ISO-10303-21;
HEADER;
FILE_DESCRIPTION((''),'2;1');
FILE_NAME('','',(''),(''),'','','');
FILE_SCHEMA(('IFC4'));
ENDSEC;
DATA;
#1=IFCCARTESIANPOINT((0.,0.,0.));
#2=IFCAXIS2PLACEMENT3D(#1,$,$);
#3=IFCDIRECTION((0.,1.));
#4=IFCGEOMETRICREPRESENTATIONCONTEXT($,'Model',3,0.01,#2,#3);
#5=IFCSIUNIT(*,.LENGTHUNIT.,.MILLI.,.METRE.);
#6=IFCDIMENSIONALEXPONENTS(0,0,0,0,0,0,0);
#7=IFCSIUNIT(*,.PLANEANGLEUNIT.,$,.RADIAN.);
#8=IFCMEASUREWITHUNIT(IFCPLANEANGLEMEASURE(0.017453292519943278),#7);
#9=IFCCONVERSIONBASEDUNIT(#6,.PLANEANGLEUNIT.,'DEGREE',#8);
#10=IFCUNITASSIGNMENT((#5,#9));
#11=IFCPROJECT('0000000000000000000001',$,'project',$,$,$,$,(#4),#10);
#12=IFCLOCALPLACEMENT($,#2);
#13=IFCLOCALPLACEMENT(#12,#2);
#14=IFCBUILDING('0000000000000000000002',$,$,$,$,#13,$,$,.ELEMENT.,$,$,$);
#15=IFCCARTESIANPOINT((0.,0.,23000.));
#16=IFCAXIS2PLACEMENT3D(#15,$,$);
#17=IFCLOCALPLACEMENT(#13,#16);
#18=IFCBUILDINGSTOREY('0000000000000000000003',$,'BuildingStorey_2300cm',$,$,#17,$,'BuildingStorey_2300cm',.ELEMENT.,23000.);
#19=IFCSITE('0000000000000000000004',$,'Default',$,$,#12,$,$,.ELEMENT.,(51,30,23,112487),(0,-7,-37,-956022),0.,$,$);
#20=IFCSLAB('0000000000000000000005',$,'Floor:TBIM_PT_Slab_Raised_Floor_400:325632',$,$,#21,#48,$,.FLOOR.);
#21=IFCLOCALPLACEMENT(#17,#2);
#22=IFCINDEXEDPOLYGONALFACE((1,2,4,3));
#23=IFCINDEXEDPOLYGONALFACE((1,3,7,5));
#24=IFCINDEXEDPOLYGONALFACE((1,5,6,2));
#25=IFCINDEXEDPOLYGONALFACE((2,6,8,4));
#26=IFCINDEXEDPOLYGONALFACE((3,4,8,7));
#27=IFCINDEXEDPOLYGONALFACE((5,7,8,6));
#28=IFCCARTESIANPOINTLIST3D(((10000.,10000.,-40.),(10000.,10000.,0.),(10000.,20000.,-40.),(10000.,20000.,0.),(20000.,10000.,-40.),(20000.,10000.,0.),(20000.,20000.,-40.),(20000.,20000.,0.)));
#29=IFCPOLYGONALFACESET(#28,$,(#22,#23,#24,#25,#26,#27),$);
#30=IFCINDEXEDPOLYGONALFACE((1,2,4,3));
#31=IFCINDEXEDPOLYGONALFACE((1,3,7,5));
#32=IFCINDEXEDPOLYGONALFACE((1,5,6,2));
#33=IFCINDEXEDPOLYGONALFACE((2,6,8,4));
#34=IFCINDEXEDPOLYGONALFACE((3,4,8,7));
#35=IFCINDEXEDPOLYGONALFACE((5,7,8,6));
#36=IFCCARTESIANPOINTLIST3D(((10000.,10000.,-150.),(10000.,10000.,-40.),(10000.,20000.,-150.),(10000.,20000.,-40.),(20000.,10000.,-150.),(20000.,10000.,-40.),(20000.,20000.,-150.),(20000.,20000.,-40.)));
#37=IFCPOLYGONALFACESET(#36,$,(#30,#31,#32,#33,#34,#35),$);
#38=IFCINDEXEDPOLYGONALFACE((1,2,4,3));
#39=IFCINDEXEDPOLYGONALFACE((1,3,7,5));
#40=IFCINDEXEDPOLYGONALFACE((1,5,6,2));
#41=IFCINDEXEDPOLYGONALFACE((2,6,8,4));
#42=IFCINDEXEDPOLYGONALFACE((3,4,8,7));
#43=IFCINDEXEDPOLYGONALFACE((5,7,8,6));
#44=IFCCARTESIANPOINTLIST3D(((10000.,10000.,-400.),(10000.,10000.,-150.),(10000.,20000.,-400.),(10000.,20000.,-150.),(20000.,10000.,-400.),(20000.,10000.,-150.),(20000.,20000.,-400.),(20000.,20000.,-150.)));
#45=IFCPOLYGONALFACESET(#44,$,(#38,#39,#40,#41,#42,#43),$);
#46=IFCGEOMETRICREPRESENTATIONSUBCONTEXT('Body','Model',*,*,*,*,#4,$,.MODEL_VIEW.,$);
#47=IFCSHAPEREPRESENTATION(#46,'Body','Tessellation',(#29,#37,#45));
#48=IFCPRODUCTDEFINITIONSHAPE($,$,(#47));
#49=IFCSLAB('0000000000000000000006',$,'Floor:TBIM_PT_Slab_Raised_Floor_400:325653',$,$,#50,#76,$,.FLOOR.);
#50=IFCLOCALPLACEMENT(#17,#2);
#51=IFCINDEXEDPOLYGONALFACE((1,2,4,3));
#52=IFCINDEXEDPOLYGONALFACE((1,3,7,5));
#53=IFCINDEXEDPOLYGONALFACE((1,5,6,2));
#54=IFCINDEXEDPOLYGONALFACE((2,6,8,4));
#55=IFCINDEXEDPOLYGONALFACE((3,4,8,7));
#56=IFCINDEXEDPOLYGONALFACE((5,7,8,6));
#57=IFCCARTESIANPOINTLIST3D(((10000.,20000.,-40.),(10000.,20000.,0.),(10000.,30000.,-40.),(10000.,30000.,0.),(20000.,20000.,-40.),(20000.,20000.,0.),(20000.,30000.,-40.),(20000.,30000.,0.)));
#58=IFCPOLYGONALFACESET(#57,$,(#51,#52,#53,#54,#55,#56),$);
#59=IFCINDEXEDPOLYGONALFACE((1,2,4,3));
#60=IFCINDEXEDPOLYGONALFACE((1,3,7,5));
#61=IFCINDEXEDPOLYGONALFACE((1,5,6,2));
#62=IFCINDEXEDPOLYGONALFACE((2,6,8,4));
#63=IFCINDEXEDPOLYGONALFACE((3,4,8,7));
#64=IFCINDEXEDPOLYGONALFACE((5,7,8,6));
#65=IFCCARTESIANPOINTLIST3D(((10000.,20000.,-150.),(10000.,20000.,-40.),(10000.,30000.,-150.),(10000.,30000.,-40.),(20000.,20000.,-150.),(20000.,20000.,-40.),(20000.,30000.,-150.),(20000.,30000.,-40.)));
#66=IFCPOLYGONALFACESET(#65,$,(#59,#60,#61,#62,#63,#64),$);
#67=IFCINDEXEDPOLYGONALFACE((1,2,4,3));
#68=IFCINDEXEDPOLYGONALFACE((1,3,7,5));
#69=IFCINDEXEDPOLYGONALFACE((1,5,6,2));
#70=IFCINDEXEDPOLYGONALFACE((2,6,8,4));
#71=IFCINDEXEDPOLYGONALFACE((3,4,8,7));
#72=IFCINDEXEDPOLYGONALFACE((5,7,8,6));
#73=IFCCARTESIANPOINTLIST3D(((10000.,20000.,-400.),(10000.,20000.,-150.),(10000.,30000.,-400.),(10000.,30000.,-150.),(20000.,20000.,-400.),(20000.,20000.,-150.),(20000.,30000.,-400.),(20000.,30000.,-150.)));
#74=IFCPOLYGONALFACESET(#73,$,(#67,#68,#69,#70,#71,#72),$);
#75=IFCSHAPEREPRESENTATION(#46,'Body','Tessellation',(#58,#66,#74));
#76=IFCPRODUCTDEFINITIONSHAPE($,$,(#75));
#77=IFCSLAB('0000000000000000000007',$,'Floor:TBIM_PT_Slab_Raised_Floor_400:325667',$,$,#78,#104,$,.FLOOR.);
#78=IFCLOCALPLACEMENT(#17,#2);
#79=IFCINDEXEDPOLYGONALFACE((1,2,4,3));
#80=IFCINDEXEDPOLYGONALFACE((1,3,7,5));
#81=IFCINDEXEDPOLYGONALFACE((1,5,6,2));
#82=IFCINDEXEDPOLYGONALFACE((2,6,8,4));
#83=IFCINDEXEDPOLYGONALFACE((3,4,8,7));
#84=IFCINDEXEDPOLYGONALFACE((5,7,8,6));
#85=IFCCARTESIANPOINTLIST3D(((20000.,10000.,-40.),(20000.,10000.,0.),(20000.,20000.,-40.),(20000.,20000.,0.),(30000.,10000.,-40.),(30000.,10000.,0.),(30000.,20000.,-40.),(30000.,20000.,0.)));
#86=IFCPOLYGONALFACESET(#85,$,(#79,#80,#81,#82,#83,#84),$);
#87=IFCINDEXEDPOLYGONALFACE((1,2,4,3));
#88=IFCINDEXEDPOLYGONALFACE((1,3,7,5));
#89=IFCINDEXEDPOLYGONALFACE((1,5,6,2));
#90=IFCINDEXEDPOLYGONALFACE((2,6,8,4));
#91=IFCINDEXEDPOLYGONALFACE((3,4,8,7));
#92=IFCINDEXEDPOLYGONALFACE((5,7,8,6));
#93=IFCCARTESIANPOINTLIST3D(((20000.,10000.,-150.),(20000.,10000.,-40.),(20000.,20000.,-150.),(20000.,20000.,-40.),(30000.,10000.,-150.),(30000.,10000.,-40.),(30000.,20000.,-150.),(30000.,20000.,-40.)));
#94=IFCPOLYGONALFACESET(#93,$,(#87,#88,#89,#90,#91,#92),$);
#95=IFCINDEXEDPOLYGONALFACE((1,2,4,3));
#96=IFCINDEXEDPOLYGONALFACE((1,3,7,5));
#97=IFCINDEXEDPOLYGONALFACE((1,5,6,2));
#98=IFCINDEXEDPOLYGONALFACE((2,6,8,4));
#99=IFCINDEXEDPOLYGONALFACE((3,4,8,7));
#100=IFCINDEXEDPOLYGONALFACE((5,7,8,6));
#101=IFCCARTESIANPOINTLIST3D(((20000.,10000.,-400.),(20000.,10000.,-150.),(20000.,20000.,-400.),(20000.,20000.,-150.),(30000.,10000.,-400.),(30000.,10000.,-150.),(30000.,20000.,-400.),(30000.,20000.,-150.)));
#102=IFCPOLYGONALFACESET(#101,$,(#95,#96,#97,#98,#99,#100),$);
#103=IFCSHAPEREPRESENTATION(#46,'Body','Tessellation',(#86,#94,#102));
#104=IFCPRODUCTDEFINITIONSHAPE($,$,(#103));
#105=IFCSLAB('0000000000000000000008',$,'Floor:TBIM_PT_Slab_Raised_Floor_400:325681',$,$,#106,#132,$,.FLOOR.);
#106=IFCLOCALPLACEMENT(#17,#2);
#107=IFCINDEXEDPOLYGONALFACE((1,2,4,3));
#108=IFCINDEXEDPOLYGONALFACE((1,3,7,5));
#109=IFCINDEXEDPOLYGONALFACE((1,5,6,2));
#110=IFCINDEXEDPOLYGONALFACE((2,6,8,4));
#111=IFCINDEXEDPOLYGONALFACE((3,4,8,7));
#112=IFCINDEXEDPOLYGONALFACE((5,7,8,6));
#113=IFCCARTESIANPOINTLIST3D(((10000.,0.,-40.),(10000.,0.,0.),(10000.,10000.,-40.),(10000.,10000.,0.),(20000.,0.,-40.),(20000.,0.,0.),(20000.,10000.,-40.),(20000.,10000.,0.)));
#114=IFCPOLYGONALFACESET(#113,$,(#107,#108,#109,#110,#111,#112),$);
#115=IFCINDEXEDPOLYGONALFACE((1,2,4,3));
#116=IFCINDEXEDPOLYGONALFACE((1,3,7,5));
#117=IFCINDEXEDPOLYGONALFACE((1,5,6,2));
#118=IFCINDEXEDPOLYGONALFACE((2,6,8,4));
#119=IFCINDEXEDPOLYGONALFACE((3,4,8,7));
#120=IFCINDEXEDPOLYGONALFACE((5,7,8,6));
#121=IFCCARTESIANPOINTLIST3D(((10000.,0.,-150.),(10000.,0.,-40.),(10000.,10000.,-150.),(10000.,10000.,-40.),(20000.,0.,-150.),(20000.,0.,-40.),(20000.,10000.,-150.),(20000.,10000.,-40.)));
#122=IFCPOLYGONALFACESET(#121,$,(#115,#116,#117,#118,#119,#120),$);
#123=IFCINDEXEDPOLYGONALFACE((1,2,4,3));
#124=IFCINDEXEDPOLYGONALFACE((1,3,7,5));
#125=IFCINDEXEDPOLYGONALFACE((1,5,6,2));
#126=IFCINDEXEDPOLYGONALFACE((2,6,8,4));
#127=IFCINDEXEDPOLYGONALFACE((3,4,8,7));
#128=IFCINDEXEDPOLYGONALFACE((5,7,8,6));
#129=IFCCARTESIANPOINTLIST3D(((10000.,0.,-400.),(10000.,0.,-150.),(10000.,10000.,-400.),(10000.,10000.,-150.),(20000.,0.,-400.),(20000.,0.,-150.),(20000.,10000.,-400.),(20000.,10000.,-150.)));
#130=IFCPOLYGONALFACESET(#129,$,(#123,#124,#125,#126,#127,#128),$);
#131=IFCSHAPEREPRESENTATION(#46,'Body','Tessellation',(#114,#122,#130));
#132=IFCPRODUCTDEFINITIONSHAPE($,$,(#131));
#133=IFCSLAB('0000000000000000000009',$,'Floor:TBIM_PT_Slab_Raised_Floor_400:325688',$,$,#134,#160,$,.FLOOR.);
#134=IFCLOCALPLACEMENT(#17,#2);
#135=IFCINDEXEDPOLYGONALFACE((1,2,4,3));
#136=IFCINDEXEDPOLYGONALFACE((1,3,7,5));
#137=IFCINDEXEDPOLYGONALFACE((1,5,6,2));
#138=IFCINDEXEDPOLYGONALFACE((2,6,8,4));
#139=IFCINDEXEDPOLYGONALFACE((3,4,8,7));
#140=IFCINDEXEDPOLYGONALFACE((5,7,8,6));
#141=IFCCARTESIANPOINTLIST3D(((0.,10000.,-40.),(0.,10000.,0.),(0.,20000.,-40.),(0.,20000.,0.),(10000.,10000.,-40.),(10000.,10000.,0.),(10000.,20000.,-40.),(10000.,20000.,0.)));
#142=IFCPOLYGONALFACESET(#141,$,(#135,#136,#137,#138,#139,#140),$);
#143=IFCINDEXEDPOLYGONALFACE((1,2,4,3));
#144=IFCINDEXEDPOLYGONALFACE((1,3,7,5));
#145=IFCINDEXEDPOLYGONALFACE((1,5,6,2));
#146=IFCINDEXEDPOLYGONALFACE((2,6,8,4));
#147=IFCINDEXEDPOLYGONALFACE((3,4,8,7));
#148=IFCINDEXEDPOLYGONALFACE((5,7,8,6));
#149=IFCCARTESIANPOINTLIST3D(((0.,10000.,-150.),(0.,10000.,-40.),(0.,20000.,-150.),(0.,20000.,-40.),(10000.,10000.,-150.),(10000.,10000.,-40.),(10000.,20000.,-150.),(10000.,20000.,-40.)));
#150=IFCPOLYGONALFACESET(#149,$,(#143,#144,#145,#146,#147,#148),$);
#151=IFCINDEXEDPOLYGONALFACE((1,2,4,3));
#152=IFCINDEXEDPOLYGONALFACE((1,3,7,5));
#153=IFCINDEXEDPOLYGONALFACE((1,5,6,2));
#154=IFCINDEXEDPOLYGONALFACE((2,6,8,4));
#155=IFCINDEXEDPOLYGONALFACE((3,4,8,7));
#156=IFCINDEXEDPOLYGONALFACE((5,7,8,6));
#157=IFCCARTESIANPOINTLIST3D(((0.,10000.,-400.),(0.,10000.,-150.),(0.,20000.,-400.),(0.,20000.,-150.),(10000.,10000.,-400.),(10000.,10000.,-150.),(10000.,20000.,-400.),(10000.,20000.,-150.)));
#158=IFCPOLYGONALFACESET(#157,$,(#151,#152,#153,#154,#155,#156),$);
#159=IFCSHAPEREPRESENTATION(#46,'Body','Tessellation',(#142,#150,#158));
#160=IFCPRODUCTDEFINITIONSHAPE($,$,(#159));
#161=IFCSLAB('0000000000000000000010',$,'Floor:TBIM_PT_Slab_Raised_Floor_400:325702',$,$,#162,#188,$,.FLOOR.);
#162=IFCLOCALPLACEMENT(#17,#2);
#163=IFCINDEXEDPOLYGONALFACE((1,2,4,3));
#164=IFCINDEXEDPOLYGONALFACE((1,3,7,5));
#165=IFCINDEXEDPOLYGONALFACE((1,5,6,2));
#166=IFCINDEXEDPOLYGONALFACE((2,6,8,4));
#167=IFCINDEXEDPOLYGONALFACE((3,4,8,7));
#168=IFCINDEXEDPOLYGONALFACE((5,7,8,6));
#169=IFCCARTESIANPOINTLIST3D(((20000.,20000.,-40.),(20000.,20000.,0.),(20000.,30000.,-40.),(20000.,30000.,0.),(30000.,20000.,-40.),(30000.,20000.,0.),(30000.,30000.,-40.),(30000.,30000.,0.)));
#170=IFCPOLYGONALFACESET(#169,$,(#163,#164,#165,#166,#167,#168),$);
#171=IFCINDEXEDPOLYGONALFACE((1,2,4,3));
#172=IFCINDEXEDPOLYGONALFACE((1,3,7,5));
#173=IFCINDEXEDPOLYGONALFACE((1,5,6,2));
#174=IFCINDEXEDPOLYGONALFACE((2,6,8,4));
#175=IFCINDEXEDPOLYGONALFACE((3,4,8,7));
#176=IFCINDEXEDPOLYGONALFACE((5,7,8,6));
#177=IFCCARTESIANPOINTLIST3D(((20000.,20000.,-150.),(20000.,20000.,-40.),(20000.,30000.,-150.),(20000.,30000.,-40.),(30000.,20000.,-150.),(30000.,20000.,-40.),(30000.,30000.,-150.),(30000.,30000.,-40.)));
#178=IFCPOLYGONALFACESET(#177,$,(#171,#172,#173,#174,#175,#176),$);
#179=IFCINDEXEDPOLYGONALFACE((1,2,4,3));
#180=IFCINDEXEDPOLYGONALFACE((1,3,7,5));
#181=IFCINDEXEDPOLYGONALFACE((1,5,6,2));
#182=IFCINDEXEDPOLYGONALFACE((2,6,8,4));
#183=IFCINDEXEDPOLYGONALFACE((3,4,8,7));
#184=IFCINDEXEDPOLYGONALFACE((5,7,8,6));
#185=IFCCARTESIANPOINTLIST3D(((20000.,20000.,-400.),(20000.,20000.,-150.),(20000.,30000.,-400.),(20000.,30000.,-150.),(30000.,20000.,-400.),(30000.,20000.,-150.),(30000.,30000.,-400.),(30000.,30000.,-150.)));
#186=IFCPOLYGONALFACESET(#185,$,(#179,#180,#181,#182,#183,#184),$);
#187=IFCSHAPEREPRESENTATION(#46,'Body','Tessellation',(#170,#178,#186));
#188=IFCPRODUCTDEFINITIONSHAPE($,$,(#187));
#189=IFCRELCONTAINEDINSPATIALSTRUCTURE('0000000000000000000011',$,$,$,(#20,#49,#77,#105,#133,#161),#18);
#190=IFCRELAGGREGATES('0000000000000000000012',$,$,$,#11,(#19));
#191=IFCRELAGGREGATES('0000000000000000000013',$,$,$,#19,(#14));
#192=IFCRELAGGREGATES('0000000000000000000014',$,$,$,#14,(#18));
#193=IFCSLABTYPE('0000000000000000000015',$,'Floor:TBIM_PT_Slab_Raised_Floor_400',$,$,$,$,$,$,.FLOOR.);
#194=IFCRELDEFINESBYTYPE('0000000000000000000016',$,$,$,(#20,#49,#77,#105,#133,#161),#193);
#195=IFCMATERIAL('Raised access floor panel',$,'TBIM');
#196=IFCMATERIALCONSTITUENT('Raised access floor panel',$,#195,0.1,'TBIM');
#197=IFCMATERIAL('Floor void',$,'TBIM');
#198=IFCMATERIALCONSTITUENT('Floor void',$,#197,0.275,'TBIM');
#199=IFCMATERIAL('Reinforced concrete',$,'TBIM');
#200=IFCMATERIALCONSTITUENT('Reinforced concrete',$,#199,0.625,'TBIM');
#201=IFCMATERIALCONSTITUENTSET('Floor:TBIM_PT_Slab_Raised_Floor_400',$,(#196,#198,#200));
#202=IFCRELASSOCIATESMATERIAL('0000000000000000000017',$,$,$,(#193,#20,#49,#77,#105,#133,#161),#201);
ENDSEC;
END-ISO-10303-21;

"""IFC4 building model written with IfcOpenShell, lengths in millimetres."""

from ifc_helpers import new_model, entity, si_unit, converted_unit, direction, frame, origin, place, context, subcontext, project, spatial, indexed_curve, outline, extrude, material, constituent, constituent_set, type_object, element, save


model = new_model("IFC4")

# Units and contexts
model_context = context("Model", 3, precision=0.01, world=origin(), true_north=direction((0.0, 1.0)))
body_context = subcontext(model_context, "Body", "Model", "MODEL_VIEW")
ifc_project = project(units=[si_unit("LENGTHUNIT", "METRE", prefix="MILLI"), converted_unit("PLANEANGLEUNIT", "DEGREE", entity("IfcPlaneAngleMeasure", 0.017453292519943278), si_unit("PLANEANGLEUNIT", "RADIAN"), dimensions=[0, 0, 0, 0, 0, 0, 0])], contexts=[model_context])

# Site, building, storey
site_placement = place(None, origin())
site = spatial("IfcSite", under=ifc_project, at=site_placement, Name="Default", CompositionType="ELEMENT", RefLatitude=(51, 30, 23, 112487), RefLongitude=(0, -7, -37, -956022), RefElevation=0.0)
building_placement = place(site_placement, origin())
building = spatial("IfcBuilding", under=site, at=building_placement, CompositionType="ELEMENT")
storey_placement = place(building_placement, frame((0.0, 0.0, 23000.0)))
storey = spatial("IfcBuildingStorey", under=building, at=storey_placement, Name="BuildingStorey_2300cm", LongName="BuildingStorey_2300cm", CompositionType="ELEMENT", Elevation=23000.0)

# Slabs
ifc_material_1 = material(Name="Raised access floor panel", Category="TBIM")
ifc_constituent_1 = constituent(ifc_material_1, Name="Raised access floor panel", Category="TBIM", fraction=0.1)
ifc_material_2 = material(Name="Floor void", Category="TBIM")
ifc_constituent_2 = constituent(ifc_material_2, Name="Floor void", Category="TBIM", fraction=0.275)
ifc_material_3 = material(Name="Reinforced concrete", Category="TBIM")
ifc_constituent_3 = constituent(ifc_material_3, Name="Reinforced concrete", Category="TBIM", fraction=0.625)
ifc_constituent_set_1 = constituent_set(constituents=[ifc_constituent_1, ifc_constituent_2, ifc_constituent_3], Name="Floor:TBIM_PT_Slab_Raised_Floor_400")
slab_type = type_object("IfcSlabType", Name="Floor:TBIM_PT_Slab_Raised_Floor_400", PredefinedType="FLOOR", material=ifc_constituent_set_1)
slab_1_placement = place(storey_placement, origin())
element("IfcSlab", 1, at=slab_1_placement, inside=storey, type_object=slab_type, material=ifc_constituent_set_1, Name="Floor:TBIM_PT_Slab_Raised_Floor_400:325632", PredefinedType="FLOOR", context=body_context, shape_type="SweptSolid", body=[
    extrude(outline(indexed_curve([(-5000.0, -5000.0), (5000.0, -5000.0), (5000.0, 5000.0), (-5000.0, 5000.0), (-5000.0, -5000.0)], self_intersect=False)), frame((15000.0, 15000.0, -40.0), z_axis=(0.0, 0.0, 1.0), x_axis=(-1.0, 0.0, 0.0)), (0.0, 0.0, 1.0), 40.0),
    extrude(outline(indexed_curve([(-5000.0, -5000.0), (5000.0, -5000.0), (5000.0, 5000.0), (-5000.0, 5000.0), (-5000.0, -5000.0)], self_intersect=False)), frame((15000.0, 15000.0, -150.0), z_axis=(0.0, 0.0, 1.0), x_axis=(-1.0, 0.0, 0.0)), (0.0, 0.0, 1.0), 110.0),
    extrude(outline(indexed_curve([(-5000.0, -5000.0), (5000.0, -5000.0), (5000.0, 5000.0), (-5000.0, 5000.0), (-5000.0, -5000.0)], self_intersect=False)), frame((15000.0, 15000.0, -400.0), z_axis=(0.0, 0.0, 1.0), x_axis=(-1.0, 0.0, 0.0)), (0.0, 0.0, 1.0), 250.0),
])
slab_2_placement = place(storey_placement, origin())
element("IfcSlab", 2, at=slab_2_placement, inside=storey, type_object=slab_type, material=ifc_constituent_set_1, Name="Floor:TBIM_PT_Slab_Raised_Floor_400:325653", PredefinedType="FLOOR", context=body_context, shape_type="SweptSolid", body=[
    extrude(outline(indexed_curve([(-5000.0, -5000.0), (5000.0, -5000.0), (5000.0, 5000.0), (-5000.0, 5000.0), (-5000.0, -5000.0)], self_intersect=False)), frame((15000.0, 25000.0, -40.0), z_axis=(0.0, 0.0, 1.0), x_axis=(-1.0, 0.0, 0.0)), (0.0, 0.0, 1.0), 40.0),
    extrude(outline(indexed_curve([(-5000.0, -5000.0), (5000.0, -5000.0), (5000.0, 5000.0), (-5000.0, 5000.0), (-5000.0, -5000.0)], self_intersect=False)), frame((15000.0, 25000.0, -150.0), z_axis=(0.0, 0.0, 1.0), x_axis=(-1.0, 0.0, 0.0)), (0.0, 0.0, 1.0), 110.0),
    extrude(outline(indexed_curve([(-5000.0, -5000.0), (5000.0, -5000.0), (5000.0, 5000.0), (-5000.0, 5000.0), (-5000.0, -5000.0)], self_intersect=False)), frame((15000.0, 25000.0, -400.0), z_axis=(0.0, 0.0, 1.0), x_axis=(-1.0, 0.0, 0.0)), (0.0, 0.0, 1.0), 250.0),
])
slab_3_placement = place(storey_placement, origin())
element("IfcSlab", 3, at=slab_3_placement, inside=storey, type_object=slab_type, material=ifc_constituent_set_1, Name="Floor:TBIM_PT_Slab_Raised_Floor_400:325667", PredefinedType="FLOOR", context=body_context, shape_type="SweptSolid", body=[
    extrude(outline(indexed_curve([(-5000.0, -5000.0), (5000.0, -5000.0), (5000.0, 5000.0), (-5000.0, 5000.0), (-5000.0, -5000.0)], self_intersect=False)), frame((25000.0, 15000.0, -40.0), z_axis=(0.0, 0.0, 1.0), x_axis=(-1.0, 0.0, 0.0)), (0.0, 0.0, 1.0), 40.0),
    extrude(outline(indexed_curve([(-5000.0, -5000.0), (5000.0, -5000.0), (5000.0, 5000.0), (-5000.0, 5000.0), (-5000.0, -5000.0)], self_intersect=False)), frame((25000.0, 15000.0, -150.0), z_axis=(0.0, 0.0, 1.0), x_axis=(-1.0, 0.0, 0.0)), (0.0, 0.0, 1.0), 110.0),
    extrude(outline(indexed_curve([(-5000.0, -5000.0), (5000.0, -5000.0), (5000.0, 5000.0), (-5000.0, 5000.0), (-5000.0, -5000.0)], self_intersect=False)), frame((25000.0, 15000.0, -400.0), z_axis=(0.0, 0.0, 1.0), x_axis=(-1.0, 0.0, 0.0)), (0.0, 0.0, 1.0), 250.0),
])
slab_4_placement = place(storey_placement, origin())
element("IfcSlab", 4, at=slab_4_placement, inside=storey, type_object=slab_type, material=ifc_constituent_set_1, Name="Floor:TBIM_PT_Slab_Raised_Floor_400:325681", PredefinedType="FLOOR", context=body_context, shape_type="SweptSolid", body=[
    extrude(outline(indexed_curve([(-5000.0, -5000.0), (5000.0, -5000.0), (5000.0, 5000.0), (-5000.0, 5000.0), (-5000.0, -5000.0)], self_intersect=False)), frame((15000.0, 5000.0, -40.0), z_axis=(0.0, 0.0, 1.0), x_axis=(0.0, 1.0, 0.0)), (0.0, 0.0, 1.0), 40.0),
    extrude(outline(indexed_curve([(-5000.0, -5000.0), (5000.0, -5000.0), (5000.0, 5000.0), (-5000.0, 5000.0), (-5000.0, -5000.0)], self_intersect=False)), frame((15000.0, 5000.0, -150.0), z_axis=(0.0, 0.0, 1.0), x_axis=(0.0, 1.0, 0.0)), (0.0, 0.0, 1.0), 110.0),
    extrude(outline(indexed_curve([(-5000.0, -5000.0), (5000.0, -5000.0), (5000.0, 5000.0), (-5000.0, 5000.0), (-5000.0, -5000.0)], self_intersect=False)), frame((15000.0, 5000.0, -400.0), z_axis=(0.0, 0.0, 1.0), x_axis=(0.0, 1.0, 0.0)), (0.0, 0.0, 1.0), 250.0),
])
slab_5_placement = place(storey_placement, origin())
element("IfcSlab", 5, at=slab_5_placement, inside=storey, type_object=slab_type, material=ifc_constituent_set_1, Name="Floor:TBIM_PT_Slab_Raised_Floor_400:325688", PredefinedType="FLOOR", context=body_context, shape_type="SweptSolid", body=[
    extrude(outline(indexed_curve([(-5000.0, -5000.0), (5000.0, -5000.0), (5000.0, 5000.0), (-5000.0, 5000.0), (-5000.0, -5000.0)], self_intersect=False)), frame((5000.0, 15000.0, -40.0), z_axis=(0.0, 0.0, 1.0), x_axis=(0.0, 1.0, 0.0)), (0.0, 0.0, 1.0), 40.0),
    extrude(outline(indexed_curve([(-5000.0, -5000.0), (5000.0, -5000.0), (5000.0, 5000.0), (-5000.0, 5000.0), (-5000.0, -5000.0)], self_intersect=False)), frame((5000.0, 15000.0, -150.0), z_axis=(0.0, 0.0, 1.0), x_axis=(0.0, 1.0, 0.0)), (0.0, 0.0, 1.0), 110.0),
    extrude(outline(indexed_curve([(-5000.0, -5000.0), (5000.0, -5000.0), (5000.0, 5000.0), (-5000.0, 5000.0), (-5000.0, -5000.0)], self_intersect=False)), frame((5000.0, 15000.0, -400.0), z_axis=(0.0, 0.0, 1.0), x_axis=(0.0, 1.0, 0.0)), (0.0, 0.0, 1.0), 250.0),
])
slab_6_placement = place(storey_placement, origin())
element("IfcSlab", 6, at=slab_6_placement, inside=storey, type_object=slab_type, material=ifc_constituent_set_1, Name="Floor:TBIM_PT_Slab_Raised_Floor_400:325702", PredefinedType="FLOOR", context=body_context, shape_type="SweptSolid", body=[
    extrude(outline(indexed_curve([(-5000.0, -5000.0), (5000.0, -5000.0), (5000.0, 5000.0), (-5000.0, 5000.0), (-5000.0, -5000.0)], self_intersect=False)), frame((25000.0, 25000.0, -40.0), z_axis=(0.0, 0.0, 1.0), x_axis=(-1.0, 0.0, 0.0)), (0.0, 0.0, 1.0), 40.0),
    extrude(outline(indexed_curve([(-5000.0, -5000.0), (5000.0, -5000.0), (5000.0, 5000.0), (-5000.0, 5000.0), (-5000.0, -5000.0)], self_intersect=False)), frame((25000.0, 25000.0, -150.0), z_axis=(0.0, 0.0, 1.0), x_axis=(-1.0, 0.0, 0.0)), (0.0, 0.0, 1.0), 110.0),
    extrude(outline(indexed_curve([(-5000.0, -5000.0), (5000.0, -5000.0), (5000.0, 5000.0), (-5000.0, 5000.0), (-5000.0, -5000.0)], self_intersect=False)), frame((25000.0, 25000.0, -400.0), z_axis=(0.0, 0.0, 1.0), x_axis=(-1.0, 0.0, 0.0)), (0.0, 0.0, 1.0), 250.0),
])

save(model, "model.ifc")
